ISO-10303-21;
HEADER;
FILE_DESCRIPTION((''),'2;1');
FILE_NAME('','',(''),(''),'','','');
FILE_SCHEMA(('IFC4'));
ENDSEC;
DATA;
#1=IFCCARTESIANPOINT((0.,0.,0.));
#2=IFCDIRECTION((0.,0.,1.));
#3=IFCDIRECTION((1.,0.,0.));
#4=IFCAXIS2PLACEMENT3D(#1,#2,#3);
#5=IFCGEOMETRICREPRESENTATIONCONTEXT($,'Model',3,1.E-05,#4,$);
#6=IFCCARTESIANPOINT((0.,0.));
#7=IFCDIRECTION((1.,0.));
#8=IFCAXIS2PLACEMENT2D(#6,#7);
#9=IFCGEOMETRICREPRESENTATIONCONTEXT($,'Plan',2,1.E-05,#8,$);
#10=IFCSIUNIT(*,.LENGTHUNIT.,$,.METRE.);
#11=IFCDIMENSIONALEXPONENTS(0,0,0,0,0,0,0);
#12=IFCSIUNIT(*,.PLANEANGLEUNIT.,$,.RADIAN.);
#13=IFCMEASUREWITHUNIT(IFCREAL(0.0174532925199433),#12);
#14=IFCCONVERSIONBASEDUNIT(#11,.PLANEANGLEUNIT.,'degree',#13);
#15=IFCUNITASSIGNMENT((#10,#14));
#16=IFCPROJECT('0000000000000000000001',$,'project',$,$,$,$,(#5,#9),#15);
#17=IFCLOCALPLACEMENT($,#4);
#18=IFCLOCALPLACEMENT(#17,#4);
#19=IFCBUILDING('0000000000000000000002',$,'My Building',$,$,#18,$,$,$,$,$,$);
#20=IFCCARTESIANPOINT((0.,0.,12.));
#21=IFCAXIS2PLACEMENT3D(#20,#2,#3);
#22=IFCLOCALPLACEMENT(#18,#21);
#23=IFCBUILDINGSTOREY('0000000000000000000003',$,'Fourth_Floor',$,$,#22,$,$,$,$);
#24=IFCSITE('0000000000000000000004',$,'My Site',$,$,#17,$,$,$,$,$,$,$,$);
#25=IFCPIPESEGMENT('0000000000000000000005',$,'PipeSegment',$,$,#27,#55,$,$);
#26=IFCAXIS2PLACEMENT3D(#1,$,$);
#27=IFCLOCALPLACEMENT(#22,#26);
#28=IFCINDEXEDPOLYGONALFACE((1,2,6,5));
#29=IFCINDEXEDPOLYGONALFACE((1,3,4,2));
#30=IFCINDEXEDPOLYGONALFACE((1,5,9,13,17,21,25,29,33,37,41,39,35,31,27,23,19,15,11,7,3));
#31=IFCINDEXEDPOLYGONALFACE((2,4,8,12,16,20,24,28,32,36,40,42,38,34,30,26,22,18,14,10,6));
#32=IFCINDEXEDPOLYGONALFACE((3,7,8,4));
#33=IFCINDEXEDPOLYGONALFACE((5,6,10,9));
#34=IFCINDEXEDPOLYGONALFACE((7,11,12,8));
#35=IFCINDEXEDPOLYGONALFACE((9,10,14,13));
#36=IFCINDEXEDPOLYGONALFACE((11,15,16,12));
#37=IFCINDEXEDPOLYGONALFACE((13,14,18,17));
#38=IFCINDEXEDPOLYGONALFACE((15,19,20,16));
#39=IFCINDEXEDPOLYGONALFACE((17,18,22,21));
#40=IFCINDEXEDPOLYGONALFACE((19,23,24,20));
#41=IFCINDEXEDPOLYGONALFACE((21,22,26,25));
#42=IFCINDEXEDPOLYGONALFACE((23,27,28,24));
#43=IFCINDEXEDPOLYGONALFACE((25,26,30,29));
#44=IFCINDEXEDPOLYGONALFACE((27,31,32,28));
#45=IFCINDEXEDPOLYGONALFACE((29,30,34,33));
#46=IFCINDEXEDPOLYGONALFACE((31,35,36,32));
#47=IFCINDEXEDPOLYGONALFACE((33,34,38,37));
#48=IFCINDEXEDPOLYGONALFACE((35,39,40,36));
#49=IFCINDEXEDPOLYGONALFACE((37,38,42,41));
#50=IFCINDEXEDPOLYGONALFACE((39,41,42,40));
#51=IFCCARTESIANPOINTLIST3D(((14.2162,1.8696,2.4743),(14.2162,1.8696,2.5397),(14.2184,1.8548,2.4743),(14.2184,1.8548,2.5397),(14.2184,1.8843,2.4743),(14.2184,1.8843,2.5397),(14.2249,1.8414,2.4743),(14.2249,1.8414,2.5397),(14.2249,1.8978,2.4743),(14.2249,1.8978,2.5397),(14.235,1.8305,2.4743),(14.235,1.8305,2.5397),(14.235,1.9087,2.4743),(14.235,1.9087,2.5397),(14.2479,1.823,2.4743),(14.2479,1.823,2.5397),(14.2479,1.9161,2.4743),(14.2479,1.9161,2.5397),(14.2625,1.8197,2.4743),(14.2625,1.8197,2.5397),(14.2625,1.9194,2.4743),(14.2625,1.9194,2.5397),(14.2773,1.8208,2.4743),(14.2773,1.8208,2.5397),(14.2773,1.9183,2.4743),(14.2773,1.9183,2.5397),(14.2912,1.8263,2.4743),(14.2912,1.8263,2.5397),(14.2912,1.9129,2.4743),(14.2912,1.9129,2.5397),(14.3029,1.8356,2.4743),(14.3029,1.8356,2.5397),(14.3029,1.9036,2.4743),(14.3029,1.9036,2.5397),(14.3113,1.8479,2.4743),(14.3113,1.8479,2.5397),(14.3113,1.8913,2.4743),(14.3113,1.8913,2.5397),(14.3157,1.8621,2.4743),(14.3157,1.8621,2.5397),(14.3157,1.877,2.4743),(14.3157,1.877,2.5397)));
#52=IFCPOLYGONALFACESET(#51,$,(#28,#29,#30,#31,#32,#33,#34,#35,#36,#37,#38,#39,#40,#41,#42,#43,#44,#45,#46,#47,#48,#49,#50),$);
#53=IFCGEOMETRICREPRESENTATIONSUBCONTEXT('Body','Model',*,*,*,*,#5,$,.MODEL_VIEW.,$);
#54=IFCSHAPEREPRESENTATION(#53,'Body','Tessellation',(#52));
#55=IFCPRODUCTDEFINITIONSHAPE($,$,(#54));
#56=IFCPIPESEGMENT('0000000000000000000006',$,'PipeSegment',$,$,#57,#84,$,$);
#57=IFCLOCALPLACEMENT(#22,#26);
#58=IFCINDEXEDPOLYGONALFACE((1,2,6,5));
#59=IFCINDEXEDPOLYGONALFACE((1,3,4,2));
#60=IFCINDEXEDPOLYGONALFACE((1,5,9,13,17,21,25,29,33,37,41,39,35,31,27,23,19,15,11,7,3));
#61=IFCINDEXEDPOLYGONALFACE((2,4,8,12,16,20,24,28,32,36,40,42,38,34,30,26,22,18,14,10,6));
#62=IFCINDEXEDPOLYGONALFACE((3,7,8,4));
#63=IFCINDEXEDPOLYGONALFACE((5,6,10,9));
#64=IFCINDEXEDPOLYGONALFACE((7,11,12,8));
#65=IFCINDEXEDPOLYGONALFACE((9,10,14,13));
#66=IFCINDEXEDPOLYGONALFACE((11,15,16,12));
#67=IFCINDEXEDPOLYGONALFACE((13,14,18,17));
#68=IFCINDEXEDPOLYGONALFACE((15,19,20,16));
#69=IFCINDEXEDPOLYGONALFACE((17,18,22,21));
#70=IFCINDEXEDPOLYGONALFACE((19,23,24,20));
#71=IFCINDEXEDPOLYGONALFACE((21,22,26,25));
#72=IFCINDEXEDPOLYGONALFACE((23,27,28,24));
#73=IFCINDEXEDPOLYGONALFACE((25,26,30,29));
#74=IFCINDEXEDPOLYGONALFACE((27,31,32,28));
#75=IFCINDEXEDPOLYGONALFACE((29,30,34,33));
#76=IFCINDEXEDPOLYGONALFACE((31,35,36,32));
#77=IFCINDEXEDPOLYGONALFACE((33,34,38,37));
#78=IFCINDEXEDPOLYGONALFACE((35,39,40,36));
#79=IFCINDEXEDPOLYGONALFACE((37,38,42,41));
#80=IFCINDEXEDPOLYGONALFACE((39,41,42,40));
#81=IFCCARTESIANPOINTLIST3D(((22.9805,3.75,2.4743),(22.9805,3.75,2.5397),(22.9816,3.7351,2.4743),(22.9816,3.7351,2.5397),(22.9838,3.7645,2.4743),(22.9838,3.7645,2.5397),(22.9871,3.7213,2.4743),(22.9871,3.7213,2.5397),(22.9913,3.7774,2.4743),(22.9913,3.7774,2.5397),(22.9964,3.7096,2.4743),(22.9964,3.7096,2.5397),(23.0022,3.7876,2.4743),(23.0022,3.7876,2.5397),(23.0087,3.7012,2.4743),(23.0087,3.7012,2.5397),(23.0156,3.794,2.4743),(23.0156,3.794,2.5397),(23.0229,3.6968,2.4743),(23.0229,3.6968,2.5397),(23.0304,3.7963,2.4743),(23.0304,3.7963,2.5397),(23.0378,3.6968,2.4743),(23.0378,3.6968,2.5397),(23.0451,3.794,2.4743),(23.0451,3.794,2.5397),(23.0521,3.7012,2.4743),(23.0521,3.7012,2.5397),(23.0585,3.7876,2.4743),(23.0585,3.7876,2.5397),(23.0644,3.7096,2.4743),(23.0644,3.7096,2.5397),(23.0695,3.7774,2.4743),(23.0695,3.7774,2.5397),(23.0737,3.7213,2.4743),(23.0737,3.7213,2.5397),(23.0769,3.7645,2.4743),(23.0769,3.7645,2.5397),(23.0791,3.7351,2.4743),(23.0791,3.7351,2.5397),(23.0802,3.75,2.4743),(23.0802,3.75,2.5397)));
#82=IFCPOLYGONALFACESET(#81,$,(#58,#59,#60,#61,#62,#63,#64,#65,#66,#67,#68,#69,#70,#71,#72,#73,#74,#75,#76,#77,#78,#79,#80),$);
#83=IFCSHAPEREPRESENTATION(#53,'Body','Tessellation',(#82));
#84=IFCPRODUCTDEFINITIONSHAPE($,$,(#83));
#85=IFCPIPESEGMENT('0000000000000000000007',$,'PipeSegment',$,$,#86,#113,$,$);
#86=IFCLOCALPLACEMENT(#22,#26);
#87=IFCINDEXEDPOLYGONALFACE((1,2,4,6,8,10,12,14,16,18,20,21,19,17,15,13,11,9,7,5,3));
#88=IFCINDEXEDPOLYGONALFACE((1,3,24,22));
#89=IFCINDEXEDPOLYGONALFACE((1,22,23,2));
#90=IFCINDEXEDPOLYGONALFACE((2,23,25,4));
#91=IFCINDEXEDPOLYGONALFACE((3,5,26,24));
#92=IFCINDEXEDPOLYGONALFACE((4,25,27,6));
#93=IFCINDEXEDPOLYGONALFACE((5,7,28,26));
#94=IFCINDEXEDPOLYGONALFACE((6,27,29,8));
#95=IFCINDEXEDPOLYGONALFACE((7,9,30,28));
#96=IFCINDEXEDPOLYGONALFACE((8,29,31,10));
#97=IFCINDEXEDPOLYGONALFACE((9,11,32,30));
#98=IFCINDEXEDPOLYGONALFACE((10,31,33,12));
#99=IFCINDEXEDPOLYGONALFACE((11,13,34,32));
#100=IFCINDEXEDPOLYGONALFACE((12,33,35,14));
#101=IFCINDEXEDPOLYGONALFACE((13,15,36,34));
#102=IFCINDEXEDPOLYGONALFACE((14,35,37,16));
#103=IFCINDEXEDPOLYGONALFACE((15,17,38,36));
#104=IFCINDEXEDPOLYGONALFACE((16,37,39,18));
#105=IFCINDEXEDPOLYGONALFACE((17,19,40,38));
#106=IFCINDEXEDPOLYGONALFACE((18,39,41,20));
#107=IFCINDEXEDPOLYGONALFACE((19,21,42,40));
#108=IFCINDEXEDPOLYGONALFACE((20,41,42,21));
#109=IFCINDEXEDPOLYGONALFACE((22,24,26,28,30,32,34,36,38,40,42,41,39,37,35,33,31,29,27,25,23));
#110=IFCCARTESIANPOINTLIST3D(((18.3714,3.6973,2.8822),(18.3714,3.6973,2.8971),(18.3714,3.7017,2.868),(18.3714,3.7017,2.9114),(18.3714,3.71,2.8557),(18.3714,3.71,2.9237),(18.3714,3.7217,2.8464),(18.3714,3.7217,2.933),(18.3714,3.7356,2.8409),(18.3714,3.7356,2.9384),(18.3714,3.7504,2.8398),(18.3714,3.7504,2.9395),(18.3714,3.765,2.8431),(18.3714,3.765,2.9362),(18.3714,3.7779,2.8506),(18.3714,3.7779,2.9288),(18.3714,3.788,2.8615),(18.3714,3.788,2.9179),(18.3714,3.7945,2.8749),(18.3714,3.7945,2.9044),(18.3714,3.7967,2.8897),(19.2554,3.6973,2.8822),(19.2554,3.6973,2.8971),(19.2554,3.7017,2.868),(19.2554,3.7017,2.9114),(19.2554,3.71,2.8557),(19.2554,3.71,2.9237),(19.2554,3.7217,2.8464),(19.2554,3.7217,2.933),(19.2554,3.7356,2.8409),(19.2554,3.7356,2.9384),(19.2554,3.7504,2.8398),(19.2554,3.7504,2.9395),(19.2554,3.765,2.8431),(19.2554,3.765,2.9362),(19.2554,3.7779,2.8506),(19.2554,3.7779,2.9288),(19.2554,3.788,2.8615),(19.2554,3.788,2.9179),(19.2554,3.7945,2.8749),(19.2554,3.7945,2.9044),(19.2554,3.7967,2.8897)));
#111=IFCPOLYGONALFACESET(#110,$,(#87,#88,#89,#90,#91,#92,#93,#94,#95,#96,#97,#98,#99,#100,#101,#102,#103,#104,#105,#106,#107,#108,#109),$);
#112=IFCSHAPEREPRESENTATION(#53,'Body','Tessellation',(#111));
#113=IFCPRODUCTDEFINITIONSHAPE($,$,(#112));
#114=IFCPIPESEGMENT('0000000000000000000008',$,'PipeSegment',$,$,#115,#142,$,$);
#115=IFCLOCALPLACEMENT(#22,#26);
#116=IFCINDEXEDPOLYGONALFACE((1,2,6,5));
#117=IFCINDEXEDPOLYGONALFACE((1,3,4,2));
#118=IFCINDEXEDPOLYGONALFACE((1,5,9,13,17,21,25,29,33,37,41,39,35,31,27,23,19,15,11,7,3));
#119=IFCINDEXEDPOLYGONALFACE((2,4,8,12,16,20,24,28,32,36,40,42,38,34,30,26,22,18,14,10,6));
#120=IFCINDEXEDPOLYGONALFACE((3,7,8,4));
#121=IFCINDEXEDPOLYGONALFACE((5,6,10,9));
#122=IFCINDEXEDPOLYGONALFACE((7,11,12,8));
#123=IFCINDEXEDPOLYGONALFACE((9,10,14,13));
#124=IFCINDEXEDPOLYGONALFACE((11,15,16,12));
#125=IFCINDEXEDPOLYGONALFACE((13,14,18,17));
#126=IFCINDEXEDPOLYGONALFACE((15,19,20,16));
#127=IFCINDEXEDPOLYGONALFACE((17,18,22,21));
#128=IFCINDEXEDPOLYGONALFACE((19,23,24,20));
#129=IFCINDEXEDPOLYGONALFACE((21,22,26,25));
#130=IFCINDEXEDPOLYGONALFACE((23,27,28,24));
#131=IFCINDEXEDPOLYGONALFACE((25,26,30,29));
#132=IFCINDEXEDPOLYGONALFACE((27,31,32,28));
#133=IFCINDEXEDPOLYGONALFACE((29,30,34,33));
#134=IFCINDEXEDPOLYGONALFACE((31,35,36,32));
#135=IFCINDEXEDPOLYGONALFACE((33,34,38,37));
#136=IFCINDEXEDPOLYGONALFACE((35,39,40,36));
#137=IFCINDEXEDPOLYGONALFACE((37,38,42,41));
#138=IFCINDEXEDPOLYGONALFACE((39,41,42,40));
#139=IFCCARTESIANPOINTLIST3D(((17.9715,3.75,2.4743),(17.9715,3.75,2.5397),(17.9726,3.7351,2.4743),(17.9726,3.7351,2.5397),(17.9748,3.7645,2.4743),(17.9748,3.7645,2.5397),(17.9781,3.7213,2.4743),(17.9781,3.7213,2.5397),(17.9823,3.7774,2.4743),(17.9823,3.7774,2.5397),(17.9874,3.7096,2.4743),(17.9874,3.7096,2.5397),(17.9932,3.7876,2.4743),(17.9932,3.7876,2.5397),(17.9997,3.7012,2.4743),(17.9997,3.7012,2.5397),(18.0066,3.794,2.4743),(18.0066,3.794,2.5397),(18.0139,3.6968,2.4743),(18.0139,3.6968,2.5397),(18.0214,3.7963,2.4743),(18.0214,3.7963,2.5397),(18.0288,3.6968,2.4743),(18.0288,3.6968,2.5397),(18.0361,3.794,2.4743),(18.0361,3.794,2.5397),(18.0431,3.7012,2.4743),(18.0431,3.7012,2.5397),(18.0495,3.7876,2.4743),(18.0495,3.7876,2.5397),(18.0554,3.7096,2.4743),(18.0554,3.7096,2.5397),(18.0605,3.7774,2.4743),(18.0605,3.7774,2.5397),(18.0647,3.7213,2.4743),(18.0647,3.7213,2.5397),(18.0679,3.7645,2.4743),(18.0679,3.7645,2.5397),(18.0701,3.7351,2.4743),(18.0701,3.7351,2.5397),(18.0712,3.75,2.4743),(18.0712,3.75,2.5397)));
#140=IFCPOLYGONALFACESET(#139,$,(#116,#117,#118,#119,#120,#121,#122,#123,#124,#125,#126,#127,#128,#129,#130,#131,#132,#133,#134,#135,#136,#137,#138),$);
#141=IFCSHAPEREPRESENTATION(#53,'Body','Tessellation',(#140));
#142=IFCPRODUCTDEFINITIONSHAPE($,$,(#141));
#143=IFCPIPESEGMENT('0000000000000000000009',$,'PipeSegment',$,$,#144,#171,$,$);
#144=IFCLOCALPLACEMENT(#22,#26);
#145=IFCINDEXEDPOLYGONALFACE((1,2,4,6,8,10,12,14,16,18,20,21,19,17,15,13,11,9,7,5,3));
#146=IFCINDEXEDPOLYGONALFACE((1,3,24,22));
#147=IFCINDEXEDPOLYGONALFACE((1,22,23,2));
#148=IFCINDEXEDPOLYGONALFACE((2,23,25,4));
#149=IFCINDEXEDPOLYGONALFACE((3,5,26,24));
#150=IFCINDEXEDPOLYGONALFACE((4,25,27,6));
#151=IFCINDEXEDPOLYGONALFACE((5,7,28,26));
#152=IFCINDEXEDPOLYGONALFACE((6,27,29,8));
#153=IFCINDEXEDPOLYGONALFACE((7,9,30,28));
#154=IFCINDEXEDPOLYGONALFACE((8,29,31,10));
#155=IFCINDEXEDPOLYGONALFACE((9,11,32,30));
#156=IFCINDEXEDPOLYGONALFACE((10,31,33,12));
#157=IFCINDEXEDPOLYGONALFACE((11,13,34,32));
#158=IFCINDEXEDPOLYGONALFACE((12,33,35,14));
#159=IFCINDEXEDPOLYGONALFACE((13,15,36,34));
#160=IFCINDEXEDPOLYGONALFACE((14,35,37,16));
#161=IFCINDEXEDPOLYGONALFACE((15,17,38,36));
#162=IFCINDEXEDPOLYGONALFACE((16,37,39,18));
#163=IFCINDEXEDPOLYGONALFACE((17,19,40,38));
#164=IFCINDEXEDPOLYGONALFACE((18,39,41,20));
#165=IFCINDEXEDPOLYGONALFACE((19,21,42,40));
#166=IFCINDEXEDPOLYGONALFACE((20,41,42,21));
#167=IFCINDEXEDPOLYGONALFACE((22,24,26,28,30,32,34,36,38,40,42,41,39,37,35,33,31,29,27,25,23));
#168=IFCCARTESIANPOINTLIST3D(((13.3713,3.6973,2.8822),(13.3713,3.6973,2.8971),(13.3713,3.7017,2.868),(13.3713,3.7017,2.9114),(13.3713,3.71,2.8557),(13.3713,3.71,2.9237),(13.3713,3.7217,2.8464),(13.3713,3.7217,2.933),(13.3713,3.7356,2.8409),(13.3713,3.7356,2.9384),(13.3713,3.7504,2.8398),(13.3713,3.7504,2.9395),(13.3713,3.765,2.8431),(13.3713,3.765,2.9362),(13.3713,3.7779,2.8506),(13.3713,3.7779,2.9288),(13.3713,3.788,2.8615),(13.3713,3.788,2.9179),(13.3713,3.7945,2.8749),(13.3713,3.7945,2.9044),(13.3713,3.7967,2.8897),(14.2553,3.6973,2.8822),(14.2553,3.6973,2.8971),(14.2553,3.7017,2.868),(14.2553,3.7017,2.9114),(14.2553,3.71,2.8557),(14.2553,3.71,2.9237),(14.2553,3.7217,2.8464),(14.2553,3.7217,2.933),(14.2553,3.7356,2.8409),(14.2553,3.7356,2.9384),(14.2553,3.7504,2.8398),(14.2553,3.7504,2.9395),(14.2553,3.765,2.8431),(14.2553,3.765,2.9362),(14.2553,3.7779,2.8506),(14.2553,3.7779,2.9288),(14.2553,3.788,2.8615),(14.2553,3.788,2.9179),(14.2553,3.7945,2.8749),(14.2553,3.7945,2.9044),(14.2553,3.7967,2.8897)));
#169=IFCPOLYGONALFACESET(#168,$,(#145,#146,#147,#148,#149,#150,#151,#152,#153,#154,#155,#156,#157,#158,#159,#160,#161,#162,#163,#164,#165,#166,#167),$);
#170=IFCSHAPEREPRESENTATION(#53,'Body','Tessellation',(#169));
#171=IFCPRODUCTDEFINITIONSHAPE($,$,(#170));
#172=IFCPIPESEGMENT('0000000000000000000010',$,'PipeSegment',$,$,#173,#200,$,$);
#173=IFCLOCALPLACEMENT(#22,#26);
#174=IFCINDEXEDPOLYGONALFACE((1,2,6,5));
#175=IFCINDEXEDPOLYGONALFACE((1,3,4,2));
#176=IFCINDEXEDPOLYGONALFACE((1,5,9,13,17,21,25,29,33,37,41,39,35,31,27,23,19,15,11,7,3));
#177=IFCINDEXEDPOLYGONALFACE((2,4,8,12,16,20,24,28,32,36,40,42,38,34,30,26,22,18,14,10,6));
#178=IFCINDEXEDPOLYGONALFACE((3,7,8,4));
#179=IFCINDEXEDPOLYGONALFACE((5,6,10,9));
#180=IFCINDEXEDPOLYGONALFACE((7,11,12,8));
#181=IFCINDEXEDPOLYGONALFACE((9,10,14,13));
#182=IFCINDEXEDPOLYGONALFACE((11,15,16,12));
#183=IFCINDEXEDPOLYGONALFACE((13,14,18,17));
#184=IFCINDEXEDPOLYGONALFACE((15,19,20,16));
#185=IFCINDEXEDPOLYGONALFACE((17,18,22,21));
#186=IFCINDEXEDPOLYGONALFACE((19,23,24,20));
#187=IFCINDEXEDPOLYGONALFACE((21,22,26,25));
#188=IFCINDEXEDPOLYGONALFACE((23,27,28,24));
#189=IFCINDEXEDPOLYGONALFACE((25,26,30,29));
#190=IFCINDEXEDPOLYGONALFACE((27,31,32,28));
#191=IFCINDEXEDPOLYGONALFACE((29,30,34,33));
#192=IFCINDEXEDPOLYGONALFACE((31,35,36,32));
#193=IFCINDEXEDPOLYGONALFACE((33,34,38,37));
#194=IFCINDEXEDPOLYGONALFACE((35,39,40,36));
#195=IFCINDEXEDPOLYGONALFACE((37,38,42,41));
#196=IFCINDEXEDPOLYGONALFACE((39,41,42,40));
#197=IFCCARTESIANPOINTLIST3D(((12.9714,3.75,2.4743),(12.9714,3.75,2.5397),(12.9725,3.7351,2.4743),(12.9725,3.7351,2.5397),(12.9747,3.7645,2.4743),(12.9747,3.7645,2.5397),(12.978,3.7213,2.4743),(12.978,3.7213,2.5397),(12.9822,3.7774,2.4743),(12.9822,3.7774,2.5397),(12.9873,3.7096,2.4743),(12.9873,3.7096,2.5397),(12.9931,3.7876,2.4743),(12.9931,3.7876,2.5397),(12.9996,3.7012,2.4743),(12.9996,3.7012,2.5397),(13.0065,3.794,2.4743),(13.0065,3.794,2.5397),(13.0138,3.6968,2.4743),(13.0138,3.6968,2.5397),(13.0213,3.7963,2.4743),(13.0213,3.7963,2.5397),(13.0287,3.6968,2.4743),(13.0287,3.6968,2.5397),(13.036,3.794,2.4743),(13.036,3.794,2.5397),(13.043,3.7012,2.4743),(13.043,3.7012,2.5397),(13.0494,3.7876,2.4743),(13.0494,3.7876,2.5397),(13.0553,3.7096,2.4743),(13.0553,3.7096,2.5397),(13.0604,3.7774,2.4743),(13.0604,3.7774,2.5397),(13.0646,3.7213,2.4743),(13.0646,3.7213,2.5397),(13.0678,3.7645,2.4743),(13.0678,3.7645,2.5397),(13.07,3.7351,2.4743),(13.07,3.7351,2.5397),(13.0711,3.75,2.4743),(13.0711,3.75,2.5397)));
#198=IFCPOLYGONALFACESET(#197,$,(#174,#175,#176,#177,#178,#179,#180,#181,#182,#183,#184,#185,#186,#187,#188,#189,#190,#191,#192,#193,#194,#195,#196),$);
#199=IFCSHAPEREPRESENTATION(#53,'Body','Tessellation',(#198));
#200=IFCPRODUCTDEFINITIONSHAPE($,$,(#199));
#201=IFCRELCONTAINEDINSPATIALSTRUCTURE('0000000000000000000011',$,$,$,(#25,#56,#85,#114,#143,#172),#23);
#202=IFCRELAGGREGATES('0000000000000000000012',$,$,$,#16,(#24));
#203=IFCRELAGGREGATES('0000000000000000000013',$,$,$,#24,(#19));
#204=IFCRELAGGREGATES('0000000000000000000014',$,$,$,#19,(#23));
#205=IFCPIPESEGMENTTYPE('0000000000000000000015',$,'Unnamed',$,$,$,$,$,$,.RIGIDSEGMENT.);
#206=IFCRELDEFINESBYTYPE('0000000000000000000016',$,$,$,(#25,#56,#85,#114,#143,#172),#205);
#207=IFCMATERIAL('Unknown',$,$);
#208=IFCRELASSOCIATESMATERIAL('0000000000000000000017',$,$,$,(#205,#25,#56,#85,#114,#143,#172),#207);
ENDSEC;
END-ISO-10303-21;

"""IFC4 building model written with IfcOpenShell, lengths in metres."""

from ifc_helpers import new_model, entity, si_unit, converted_unit, frame, origin_with_axes, origin_2d_with_axis, place, context, subcontext, project, spatial, circle, extrude, material, material_profile, profile_set, profile_usage, type_object, element, save


model = new_model("IFC4")

# Units and contexts
model_context = context("Model", 3, precision=1e-05, world=origin_with_axes())
plan_context = context("Plan", 2, precision=1e-05, world=origin_2d_with_axis())
body_context_1 = subcontext(model_context, "Body", "Model", "MODEL_VIEW")
ifc_project = project(units=[si_unit("LENGTHUNIT", "METRE"), converted_unit("PLANEANGLEUNIT", "degree", entity("IfcReal", 0.0174532925199433), si_unit("PLANEANGLEUNIT", "RADIAN"), dimensions=[0, 0, 0, 0, 0, 0, 0])], contexts=[model_context, plan_context])

# Site, building, storey
site_placement = place(None, origin_with_axes())
site = spatial("IfcSite", under=ifc_project, at=site_placement, Name="My Site")
building_placement = place(site_placement, origin_with_axes())
building = spatial("IfcBuilding", under=site, at=building_placement, Name="My Building")
storey_placement = place(building_placement, frame((0.0, 0.0, 12.0), z_axis=(0.0, 0.0, 1.0), x_axis=(1.0, 0.0, 0.0)))
storey = spatial("IfcBuildingStorey", under=building, at=storey_placement, Name="Fourth_Floor")

# Shared definitions
ifc_material = material(Name="Unknown")

# Pipe segments
ifc_material_profile_1 = material_profile(ifc_material, circle(Radius=0.05))
ifc_profile_set_1 = profile_set([ifc_material_profile_1])
ifc_profile_usage_1 = profile_usage(ifc_profile_set_1, cardinal=5)
pipe_segment_type = type_object("IfcPipeSegmentType", Name="Unnamed", PredefinedType="RIGIDSEGMENT", material=ifc_profile_set_1)
pipe_segment_1_placement = place(storey_placement, frame((14.2662, 1.8696, 2.4743), z_axis=(0.0, 0.0, 1.0), x_axis=(-1.0, 0.0, 0.0)))
element("IfcPipeSegment", 1, at=pipe_segment_1_placement, inside=storey, type_object=pipe_segment_type, material=ifc_profile_usage_1, Name="PipeSegment", context=body_context_1, shape_type="SweptSolid", body=[
    extrude(circle(Radius=0.05), origin_with_axes(), (0.0, 0.0, 1.0), 0.0654),
])
ifc_profile_usage_2 = profile_usage(ifc_profile_set_1, cardinal=5)
pipe_segment_2_placement = place(storey_placement, frame((23.0304, 3.7463, 2.4743), z_axis=(0.0, 0.0, 1.0), x_axis=(-0.000001, 1.0, 0.0)))
element("IfcPipeSegment", 2, at=pipe_segment_2_placement, inside=storey, type_object=pipe_segment_type, material=ifc_profile_usage_2, Name="PipeSegment", context=body_context_1, shape_type="SweptSolid", body=[
    extrude(circle(Radius=0.05), origin_with_axes(), (0.0, 0.0, 1.0), 0.0654),
])
ifc_profile_usage_3 = profile_usage(ifc_profile_set_1, cardinal=5)
pipe_segment_3_placement = place(storey_placement, frame((18.3714, 3.7467, 2.8897), z_axis=(1.0, 0.0, 0.0), x_axis=(0.0, 1.0, 0.0)))
element("IfcPipeSegment", 3, at=pipe_segment_3_placement, inside=storey, type_object=pipe_segment_type, material=ifc_profile_usage_3, Name="PipeSegment", context=body_context_1, shape_type="SweptSolid", body=[
    extrude(circle(Radius=0.05), origin_with_axes(), (0.0, 0.0, 1.0), 0.884),
])
ifc_profile_usage_4 = profile_usage(ifc_profile_set_1, cardinal=5)
pipe_segment_4_placement = place(storey_placement, frame((18.0214, 3.7463, 2.4743), z_axis=(0.0, 0.0, 1.0), x_axis=(-0.000001, 1.0, 0.0)))
element("IfcPipeSegment", 4, at=pipe_segment_4_placement, inside=storey, type_object=pipe_segment_type, material=ifc_profile_usage_4, Name="PipeSegment", context=body_context_1, shape_type="SweptSolid", body=[
    extrude(circle(Radius=0.05), origin_with_axes(), (0.0, 0.0, 1.0), 0.0654),
])
ifc_profile_usage_5 = profile_usage(ifc_profile_set_1, cardinal=5)
pipe_segment_5_placement = place(storey_placement, frame((13.3713, 3.7467, 2.8897), z_axis=(1.0, 0.0, 0.0), x_axis=(0.0, 1.0, 0.0)))
element("IfcPipeSegment", 5, at=pipe_segment_5_placement, inside=storey, type_object=pipe_segment_type, material=ifc_profile_usage_5, Name="PipeSegment", context=body_context_1, shape_type="SweptSolid", body=[
    extrude(circle(Radius=0.05), origin_with_axes(), (0.0, 0.0, 1.0), 0.884),
])
ifc_profile_usage_6 = profile_usage(ifc_profile_set_1, cardinal=5)
pipe_segment_6_placement = place(storey_placement, frame((13.0213, 3.7463, 2.4743), z_axis=(0.0, 0.0, 1.0), x_axis=(-0.000001, 1.0, 0.0)))
element("IfcPipeSegment", 6, at=pipe_segment_6_placement, inside=storey, type_object=pipe_segment_type, material=ifc_profile_usage_6, Name="PipeSegment", context=body_context_1, shape_type="SweptSolid", body=[
    extrude(circle(Radius=0.05), origin_with_axes(), (0.0, 0.0, 1.0), 0.0654),
])

save(model, "model.ifc")
